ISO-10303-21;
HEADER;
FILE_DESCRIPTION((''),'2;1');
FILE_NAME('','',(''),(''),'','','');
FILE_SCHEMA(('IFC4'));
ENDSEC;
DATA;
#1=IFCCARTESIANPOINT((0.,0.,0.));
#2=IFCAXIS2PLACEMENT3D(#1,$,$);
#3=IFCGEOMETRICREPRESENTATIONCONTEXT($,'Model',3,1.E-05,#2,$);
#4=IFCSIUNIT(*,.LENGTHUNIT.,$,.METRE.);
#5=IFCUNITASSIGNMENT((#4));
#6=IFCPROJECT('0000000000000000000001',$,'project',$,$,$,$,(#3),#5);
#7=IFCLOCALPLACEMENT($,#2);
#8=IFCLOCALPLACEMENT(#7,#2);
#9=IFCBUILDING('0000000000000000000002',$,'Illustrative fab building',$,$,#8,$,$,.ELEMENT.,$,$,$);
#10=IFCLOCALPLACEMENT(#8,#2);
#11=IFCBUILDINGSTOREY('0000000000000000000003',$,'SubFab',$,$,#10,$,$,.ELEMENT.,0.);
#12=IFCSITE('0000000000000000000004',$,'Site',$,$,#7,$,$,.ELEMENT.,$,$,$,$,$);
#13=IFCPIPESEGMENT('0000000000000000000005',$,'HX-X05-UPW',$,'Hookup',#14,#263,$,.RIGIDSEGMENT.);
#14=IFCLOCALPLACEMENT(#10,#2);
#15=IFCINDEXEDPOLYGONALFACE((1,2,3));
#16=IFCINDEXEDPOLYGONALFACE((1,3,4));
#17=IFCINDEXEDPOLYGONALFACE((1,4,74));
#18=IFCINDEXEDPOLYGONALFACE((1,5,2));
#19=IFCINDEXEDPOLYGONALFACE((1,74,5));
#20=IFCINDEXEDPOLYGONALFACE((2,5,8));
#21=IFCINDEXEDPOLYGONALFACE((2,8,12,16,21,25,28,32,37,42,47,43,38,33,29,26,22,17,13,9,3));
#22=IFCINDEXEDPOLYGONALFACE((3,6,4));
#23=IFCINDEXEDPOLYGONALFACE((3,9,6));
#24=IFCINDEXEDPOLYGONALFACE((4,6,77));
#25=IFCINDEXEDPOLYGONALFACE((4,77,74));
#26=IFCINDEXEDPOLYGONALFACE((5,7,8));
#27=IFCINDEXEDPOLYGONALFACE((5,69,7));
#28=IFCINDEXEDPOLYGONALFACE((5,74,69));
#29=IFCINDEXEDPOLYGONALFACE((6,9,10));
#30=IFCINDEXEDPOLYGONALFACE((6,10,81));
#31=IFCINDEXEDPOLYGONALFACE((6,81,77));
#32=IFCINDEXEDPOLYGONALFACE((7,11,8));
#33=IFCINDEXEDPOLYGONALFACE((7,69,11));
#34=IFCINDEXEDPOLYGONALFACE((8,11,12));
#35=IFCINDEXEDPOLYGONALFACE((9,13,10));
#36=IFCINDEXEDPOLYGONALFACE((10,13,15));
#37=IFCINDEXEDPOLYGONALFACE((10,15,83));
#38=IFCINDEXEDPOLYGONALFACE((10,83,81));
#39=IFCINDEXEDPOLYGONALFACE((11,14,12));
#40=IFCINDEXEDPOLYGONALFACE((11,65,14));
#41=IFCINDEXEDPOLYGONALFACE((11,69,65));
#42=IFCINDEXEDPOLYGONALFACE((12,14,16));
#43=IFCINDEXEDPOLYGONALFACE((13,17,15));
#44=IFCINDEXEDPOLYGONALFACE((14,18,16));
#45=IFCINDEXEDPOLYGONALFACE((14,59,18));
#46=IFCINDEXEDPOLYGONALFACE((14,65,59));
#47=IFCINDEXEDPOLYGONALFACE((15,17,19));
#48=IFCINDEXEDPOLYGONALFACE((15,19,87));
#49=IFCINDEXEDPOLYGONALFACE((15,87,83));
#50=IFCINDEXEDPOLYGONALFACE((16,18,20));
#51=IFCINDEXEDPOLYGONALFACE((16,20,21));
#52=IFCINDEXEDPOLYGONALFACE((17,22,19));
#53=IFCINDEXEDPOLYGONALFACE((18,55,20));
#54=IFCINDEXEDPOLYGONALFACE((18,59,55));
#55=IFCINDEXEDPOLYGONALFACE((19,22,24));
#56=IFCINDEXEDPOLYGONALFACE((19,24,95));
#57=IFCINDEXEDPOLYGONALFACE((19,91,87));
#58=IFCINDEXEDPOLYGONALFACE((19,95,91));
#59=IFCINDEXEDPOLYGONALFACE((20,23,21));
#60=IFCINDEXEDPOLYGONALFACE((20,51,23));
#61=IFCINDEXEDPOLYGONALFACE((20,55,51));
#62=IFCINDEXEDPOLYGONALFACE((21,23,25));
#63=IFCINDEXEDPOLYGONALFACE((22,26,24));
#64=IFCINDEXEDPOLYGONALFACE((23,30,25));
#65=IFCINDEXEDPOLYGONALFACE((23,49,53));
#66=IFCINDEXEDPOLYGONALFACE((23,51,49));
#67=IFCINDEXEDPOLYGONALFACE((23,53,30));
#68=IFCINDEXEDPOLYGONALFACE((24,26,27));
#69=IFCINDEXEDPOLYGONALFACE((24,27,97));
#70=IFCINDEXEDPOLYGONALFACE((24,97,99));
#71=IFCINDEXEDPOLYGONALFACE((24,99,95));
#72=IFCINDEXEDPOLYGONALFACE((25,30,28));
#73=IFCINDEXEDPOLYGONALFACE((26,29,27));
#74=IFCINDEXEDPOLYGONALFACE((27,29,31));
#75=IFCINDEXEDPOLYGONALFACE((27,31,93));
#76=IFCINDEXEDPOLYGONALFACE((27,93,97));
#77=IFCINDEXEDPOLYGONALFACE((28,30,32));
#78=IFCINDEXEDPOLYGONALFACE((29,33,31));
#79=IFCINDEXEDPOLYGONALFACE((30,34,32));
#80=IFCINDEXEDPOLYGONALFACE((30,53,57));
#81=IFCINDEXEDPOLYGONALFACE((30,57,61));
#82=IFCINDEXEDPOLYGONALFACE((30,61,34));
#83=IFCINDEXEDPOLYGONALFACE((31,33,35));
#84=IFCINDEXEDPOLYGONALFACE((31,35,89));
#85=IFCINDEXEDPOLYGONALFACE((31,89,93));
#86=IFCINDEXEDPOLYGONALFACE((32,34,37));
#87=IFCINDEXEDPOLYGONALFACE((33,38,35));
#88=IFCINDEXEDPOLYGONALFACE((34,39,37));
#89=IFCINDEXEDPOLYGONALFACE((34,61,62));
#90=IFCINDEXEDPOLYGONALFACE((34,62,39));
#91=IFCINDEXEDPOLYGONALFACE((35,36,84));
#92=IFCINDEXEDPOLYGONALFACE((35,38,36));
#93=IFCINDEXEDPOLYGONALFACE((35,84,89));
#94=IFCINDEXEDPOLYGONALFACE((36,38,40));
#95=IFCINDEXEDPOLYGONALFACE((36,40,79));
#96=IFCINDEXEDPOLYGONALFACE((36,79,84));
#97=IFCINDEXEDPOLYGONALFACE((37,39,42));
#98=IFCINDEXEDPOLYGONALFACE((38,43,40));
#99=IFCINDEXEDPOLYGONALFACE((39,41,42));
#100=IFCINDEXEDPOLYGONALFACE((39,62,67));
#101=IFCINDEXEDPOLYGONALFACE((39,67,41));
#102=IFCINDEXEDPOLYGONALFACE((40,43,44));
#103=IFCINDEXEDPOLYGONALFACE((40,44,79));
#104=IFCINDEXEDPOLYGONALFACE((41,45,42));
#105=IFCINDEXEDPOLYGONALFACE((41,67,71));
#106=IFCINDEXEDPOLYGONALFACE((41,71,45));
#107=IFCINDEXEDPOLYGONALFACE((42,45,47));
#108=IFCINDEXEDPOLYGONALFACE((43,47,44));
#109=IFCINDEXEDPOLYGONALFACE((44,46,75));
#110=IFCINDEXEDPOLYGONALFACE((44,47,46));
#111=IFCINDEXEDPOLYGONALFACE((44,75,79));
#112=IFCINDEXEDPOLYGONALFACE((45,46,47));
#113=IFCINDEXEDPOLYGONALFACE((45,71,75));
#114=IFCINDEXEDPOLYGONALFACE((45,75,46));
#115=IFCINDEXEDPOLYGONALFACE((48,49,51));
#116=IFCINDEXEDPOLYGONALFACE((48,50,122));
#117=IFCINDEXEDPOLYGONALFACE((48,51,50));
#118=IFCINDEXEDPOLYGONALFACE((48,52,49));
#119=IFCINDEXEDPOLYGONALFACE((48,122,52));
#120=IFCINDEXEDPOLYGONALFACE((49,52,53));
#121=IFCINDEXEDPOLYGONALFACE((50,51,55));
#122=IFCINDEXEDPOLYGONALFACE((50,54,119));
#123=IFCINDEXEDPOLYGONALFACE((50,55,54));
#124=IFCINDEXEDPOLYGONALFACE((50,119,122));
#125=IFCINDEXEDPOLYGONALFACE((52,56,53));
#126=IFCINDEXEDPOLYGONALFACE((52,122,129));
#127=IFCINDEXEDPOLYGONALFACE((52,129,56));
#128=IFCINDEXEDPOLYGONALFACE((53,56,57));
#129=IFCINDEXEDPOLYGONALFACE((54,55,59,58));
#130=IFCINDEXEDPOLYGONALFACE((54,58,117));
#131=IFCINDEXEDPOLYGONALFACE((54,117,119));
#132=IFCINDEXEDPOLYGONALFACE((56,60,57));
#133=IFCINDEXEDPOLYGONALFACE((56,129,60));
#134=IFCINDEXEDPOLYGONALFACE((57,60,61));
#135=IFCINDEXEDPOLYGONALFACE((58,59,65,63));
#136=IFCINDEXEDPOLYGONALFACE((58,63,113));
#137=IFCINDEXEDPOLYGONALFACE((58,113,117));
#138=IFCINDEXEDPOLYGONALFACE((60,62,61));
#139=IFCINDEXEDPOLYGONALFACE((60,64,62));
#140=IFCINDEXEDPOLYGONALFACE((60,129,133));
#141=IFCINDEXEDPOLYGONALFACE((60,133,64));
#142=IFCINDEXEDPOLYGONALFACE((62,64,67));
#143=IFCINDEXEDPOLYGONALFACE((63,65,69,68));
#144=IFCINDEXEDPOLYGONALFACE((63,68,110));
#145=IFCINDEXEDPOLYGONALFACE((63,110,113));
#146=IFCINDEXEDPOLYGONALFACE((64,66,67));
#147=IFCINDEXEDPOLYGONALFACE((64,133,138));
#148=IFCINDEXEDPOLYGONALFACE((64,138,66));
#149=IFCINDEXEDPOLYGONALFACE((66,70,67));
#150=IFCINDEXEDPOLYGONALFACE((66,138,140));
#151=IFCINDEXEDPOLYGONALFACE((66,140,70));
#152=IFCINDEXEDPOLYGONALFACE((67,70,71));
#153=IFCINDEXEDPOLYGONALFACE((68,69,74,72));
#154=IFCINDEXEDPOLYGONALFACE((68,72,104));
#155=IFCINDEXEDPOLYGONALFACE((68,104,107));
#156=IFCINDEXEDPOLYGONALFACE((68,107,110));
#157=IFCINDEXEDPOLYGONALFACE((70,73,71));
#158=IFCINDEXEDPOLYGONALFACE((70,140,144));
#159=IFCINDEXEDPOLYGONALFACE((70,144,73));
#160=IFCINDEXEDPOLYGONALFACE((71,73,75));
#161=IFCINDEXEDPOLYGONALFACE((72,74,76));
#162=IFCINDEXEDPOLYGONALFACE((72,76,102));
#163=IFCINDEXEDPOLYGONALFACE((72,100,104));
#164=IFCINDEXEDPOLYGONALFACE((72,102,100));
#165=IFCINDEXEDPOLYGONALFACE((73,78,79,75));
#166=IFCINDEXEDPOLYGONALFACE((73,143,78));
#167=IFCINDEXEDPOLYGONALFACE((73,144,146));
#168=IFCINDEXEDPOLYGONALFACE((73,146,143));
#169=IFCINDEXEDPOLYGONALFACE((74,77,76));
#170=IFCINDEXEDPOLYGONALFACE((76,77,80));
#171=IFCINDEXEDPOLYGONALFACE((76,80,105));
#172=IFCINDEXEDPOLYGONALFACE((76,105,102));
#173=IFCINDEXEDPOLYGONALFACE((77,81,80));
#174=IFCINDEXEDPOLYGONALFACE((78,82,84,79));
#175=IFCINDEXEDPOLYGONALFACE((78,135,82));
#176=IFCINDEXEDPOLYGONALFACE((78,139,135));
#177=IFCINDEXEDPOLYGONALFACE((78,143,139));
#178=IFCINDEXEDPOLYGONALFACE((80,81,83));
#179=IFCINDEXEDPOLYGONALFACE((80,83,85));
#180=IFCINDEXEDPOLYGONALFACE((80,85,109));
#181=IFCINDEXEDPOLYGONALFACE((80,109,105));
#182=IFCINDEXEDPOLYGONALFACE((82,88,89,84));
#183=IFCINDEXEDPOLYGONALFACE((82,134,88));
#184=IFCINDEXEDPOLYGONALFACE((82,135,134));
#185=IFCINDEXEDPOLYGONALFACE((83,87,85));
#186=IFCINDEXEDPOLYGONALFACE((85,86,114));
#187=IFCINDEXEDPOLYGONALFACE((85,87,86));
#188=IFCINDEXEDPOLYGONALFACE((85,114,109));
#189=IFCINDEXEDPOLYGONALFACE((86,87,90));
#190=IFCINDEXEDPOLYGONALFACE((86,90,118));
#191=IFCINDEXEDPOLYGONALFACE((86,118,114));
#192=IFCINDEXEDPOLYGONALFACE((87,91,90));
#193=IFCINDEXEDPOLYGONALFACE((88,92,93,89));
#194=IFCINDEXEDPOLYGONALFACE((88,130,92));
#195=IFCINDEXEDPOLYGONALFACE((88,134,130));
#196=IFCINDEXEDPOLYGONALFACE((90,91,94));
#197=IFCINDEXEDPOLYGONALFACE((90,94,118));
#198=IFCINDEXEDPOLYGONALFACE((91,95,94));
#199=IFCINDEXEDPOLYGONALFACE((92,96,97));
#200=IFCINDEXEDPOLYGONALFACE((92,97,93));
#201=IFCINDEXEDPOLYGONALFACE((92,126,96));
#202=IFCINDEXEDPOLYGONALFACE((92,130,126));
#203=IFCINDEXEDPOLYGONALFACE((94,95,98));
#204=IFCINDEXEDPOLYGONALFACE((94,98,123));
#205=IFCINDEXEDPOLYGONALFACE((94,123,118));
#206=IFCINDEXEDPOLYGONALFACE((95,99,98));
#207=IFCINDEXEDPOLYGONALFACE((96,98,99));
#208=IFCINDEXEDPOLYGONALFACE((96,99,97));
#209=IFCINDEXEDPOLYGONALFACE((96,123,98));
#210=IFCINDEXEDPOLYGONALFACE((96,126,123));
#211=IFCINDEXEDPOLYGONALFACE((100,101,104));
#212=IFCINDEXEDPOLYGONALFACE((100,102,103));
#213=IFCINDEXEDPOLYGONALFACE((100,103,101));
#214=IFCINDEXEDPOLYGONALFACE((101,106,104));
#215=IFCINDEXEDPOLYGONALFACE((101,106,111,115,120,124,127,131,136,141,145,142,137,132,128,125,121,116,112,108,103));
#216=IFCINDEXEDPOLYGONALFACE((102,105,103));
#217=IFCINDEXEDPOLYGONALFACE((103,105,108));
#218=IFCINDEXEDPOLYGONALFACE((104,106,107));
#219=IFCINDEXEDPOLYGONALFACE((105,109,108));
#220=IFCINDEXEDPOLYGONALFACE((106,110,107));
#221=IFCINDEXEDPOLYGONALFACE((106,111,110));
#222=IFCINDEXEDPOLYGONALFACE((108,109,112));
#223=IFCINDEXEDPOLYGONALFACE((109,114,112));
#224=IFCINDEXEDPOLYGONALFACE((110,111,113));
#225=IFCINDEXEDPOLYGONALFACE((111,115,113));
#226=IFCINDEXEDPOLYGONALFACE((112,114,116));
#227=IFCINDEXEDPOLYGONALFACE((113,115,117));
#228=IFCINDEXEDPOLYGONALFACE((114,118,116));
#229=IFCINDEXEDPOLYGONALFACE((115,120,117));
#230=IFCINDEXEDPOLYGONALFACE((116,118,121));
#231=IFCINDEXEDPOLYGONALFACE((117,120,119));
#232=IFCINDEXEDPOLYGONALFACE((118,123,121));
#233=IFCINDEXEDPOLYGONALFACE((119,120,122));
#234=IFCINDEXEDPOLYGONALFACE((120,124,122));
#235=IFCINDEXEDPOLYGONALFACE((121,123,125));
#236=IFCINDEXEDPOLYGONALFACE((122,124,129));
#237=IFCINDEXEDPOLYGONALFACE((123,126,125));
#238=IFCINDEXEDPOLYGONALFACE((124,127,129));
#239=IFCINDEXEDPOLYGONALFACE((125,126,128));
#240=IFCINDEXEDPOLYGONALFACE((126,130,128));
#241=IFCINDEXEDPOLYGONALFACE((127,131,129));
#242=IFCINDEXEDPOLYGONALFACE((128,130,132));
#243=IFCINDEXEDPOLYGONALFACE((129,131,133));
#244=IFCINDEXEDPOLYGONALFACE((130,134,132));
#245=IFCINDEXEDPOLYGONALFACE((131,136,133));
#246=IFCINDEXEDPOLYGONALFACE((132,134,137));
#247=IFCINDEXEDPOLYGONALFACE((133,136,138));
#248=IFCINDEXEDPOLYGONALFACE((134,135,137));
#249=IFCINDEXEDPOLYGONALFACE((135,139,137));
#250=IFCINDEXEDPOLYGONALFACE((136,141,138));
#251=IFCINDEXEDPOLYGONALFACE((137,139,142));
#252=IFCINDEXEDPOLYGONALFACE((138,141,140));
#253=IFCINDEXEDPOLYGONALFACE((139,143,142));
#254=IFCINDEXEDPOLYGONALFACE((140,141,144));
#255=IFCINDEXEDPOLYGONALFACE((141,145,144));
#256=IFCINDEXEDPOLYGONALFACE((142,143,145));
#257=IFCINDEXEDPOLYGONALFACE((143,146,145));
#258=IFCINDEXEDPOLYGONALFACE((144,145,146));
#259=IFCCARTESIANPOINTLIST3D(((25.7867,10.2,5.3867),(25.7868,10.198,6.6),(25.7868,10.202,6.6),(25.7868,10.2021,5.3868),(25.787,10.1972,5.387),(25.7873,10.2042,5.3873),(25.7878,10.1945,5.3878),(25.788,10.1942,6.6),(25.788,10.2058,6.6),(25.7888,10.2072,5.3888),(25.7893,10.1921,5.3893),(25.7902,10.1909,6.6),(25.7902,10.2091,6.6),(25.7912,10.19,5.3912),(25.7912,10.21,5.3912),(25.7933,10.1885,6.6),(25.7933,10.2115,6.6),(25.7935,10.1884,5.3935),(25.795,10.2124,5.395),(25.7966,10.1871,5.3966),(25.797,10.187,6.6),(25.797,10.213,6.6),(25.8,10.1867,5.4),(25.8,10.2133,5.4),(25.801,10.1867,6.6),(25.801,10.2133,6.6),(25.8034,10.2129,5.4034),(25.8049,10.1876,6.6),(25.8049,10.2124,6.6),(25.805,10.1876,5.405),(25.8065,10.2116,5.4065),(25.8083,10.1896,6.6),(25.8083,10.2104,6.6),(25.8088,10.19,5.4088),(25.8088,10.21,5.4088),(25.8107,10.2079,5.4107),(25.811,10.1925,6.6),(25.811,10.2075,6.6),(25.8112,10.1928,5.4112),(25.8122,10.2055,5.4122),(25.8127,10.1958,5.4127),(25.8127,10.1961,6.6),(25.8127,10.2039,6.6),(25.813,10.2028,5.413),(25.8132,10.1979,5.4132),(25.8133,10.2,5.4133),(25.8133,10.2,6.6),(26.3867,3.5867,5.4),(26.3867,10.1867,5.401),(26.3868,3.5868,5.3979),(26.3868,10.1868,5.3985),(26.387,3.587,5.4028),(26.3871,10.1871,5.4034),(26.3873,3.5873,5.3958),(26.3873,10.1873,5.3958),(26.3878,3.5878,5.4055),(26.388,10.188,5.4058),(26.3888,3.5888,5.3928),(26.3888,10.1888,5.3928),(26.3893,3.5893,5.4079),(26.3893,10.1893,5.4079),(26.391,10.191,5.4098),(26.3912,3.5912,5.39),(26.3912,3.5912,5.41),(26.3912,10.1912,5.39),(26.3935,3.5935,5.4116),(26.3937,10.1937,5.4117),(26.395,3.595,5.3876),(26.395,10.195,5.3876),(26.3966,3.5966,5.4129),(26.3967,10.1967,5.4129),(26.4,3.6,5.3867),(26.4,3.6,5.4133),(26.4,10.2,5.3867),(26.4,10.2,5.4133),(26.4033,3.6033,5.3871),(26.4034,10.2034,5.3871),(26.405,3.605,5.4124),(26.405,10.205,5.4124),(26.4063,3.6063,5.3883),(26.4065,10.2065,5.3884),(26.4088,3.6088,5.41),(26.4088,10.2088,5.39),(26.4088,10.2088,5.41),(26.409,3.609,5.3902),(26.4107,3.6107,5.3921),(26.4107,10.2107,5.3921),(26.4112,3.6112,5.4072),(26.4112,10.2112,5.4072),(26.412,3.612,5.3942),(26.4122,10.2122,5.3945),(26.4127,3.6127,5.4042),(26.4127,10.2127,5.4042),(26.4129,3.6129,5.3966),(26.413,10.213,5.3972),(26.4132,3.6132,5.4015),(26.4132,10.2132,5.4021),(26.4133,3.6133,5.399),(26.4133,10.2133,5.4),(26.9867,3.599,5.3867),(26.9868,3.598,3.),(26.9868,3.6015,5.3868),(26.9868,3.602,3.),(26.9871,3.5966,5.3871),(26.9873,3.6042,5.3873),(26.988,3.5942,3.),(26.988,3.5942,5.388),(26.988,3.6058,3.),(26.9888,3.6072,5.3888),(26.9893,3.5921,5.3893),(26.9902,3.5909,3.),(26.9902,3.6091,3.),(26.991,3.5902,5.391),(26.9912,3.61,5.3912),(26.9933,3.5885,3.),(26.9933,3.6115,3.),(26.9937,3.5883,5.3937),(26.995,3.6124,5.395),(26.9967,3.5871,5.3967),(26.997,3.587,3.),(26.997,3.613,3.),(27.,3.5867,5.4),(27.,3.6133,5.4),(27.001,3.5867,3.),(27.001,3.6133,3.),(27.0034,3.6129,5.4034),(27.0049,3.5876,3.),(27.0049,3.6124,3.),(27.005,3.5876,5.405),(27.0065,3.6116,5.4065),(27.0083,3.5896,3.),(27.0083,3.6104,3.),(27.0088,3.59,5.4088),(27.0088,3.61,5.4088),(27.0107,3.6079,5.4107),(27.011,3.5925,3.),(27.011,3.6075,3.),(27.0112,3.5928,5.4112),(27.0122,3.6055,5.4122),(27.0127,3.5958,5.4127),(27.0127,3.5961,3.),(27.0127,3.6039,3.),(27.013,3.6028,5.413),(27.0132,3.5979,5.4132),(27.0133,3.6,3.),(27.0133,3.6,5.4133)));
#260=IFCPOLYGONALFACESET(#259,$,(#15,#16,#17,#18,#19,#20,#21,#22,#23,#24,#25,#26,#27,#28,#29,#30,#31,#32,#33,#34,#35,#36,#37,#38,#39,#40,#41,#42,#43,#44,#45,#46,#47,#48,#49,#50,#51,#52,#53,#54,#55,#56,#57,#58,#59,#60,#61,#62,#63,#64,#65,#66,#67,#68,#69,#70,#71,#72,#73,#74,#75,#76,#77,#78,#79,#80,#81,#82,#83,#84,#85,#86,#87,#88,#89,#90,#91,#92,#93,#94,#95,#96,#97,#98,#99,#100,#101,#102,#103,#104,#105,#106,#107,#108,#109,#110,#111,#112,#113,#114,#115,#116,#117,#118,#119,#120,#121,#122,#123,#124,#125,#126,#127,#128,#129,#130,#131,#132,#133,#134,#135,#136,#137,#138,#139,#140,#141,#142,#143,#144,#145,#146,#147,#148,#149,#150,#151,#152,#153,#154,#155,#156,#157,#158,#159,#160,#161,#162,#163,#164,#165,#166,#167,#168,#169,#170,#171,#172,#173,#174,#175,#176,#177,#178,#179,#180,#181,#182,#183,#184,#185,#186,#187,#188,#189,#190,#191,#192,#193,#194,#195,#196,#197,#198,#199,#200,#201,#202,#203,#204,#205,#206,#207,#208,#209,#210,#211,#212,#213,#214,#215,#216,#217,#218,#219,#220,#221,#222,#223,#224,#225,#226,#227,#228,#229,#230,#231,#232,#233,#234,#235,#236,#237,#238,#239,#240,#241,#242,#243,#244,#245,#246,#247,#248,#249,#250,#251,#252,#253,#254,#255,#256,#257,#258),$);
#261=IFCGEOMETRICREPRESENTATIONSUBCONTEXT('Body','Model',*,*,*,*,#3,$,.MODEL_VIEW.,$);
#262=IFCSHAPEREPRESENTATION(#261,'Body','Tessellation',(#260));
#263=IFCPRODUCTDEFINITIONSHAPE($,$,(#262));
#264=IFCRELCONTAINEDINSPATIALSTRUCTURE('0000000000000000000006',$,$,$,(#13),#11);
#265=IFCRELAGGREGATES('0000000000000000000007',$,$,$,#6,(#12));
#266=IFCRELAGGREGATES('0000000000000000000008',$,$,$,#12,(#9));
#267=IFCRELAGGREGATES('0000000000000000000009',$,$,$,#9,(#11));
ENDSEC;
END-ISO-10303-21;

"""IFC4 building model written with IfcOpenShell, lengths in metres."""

from ifc_helpers import new_model, entity, si_unit, origin, place, context, subcontext, project, spatial, element, save


model = new_model("IFC4")

# Units and contexts
model_context = context("Model", 3, precision=1e-05, world=origin())
body_context = subcontext(model_context, "Body", "Model", "MODEL_VIEW")
ifc_project = project(units=[si_unit("LENGTHUNIT", "METRE")], contexts=[model_context])

# Site, building, storey
site_placement = place(None, origin())
site = spatial("IfcSite", under=ifc_project, at=site_placement, Name="Site", CompositionType="ELEMENT")
building_placement = place(site_placement, origin())
building = spatial("IfcBuilding", under=site, at=building_placement, Name="Illustrative fab building", CompositionType="ELEMENT")
storey_placement = place(building_placement, origin())
storey = spatial("IfcBuildingStorey", under=building, at=storey_placement, Name="SubFab", CompositionType="ELEMENT", Elevation=0.0)

# Pipe segment
pipe_segment_1_placement = place(storey_placement, origin())
element("IfcPipeSegment", 1, at=pipe_segment_1_placement, inside=storey, Name="HX-X05-UPW", ObjectType="Hookup", PredefinedType="RIGIDSEGMENT", context=body_context, shape_type="AdvancedSweptSolid", body=[
    entity("IfcSweptDiskSolid", entity("IfcPolyline", [entity("IfcCartesianPoint", [27.0, 3.6, 3.0]), entity("IfcCartesianPoint", [27.0, 3.6, 5.4]), entity("IfcCartesianPoint", [26.4, 3.6, 5.4]), entity("IfcCartesianPoint", [26.4, 10.2, 5.4]), entity("IfcCartesianPoint", [25.8, 10.2, 5.4]), entity("IfcCartesianPoint", [25.8, 10.2, 6.6])]), 0.0133),
])

save(model, "model.ifc")
